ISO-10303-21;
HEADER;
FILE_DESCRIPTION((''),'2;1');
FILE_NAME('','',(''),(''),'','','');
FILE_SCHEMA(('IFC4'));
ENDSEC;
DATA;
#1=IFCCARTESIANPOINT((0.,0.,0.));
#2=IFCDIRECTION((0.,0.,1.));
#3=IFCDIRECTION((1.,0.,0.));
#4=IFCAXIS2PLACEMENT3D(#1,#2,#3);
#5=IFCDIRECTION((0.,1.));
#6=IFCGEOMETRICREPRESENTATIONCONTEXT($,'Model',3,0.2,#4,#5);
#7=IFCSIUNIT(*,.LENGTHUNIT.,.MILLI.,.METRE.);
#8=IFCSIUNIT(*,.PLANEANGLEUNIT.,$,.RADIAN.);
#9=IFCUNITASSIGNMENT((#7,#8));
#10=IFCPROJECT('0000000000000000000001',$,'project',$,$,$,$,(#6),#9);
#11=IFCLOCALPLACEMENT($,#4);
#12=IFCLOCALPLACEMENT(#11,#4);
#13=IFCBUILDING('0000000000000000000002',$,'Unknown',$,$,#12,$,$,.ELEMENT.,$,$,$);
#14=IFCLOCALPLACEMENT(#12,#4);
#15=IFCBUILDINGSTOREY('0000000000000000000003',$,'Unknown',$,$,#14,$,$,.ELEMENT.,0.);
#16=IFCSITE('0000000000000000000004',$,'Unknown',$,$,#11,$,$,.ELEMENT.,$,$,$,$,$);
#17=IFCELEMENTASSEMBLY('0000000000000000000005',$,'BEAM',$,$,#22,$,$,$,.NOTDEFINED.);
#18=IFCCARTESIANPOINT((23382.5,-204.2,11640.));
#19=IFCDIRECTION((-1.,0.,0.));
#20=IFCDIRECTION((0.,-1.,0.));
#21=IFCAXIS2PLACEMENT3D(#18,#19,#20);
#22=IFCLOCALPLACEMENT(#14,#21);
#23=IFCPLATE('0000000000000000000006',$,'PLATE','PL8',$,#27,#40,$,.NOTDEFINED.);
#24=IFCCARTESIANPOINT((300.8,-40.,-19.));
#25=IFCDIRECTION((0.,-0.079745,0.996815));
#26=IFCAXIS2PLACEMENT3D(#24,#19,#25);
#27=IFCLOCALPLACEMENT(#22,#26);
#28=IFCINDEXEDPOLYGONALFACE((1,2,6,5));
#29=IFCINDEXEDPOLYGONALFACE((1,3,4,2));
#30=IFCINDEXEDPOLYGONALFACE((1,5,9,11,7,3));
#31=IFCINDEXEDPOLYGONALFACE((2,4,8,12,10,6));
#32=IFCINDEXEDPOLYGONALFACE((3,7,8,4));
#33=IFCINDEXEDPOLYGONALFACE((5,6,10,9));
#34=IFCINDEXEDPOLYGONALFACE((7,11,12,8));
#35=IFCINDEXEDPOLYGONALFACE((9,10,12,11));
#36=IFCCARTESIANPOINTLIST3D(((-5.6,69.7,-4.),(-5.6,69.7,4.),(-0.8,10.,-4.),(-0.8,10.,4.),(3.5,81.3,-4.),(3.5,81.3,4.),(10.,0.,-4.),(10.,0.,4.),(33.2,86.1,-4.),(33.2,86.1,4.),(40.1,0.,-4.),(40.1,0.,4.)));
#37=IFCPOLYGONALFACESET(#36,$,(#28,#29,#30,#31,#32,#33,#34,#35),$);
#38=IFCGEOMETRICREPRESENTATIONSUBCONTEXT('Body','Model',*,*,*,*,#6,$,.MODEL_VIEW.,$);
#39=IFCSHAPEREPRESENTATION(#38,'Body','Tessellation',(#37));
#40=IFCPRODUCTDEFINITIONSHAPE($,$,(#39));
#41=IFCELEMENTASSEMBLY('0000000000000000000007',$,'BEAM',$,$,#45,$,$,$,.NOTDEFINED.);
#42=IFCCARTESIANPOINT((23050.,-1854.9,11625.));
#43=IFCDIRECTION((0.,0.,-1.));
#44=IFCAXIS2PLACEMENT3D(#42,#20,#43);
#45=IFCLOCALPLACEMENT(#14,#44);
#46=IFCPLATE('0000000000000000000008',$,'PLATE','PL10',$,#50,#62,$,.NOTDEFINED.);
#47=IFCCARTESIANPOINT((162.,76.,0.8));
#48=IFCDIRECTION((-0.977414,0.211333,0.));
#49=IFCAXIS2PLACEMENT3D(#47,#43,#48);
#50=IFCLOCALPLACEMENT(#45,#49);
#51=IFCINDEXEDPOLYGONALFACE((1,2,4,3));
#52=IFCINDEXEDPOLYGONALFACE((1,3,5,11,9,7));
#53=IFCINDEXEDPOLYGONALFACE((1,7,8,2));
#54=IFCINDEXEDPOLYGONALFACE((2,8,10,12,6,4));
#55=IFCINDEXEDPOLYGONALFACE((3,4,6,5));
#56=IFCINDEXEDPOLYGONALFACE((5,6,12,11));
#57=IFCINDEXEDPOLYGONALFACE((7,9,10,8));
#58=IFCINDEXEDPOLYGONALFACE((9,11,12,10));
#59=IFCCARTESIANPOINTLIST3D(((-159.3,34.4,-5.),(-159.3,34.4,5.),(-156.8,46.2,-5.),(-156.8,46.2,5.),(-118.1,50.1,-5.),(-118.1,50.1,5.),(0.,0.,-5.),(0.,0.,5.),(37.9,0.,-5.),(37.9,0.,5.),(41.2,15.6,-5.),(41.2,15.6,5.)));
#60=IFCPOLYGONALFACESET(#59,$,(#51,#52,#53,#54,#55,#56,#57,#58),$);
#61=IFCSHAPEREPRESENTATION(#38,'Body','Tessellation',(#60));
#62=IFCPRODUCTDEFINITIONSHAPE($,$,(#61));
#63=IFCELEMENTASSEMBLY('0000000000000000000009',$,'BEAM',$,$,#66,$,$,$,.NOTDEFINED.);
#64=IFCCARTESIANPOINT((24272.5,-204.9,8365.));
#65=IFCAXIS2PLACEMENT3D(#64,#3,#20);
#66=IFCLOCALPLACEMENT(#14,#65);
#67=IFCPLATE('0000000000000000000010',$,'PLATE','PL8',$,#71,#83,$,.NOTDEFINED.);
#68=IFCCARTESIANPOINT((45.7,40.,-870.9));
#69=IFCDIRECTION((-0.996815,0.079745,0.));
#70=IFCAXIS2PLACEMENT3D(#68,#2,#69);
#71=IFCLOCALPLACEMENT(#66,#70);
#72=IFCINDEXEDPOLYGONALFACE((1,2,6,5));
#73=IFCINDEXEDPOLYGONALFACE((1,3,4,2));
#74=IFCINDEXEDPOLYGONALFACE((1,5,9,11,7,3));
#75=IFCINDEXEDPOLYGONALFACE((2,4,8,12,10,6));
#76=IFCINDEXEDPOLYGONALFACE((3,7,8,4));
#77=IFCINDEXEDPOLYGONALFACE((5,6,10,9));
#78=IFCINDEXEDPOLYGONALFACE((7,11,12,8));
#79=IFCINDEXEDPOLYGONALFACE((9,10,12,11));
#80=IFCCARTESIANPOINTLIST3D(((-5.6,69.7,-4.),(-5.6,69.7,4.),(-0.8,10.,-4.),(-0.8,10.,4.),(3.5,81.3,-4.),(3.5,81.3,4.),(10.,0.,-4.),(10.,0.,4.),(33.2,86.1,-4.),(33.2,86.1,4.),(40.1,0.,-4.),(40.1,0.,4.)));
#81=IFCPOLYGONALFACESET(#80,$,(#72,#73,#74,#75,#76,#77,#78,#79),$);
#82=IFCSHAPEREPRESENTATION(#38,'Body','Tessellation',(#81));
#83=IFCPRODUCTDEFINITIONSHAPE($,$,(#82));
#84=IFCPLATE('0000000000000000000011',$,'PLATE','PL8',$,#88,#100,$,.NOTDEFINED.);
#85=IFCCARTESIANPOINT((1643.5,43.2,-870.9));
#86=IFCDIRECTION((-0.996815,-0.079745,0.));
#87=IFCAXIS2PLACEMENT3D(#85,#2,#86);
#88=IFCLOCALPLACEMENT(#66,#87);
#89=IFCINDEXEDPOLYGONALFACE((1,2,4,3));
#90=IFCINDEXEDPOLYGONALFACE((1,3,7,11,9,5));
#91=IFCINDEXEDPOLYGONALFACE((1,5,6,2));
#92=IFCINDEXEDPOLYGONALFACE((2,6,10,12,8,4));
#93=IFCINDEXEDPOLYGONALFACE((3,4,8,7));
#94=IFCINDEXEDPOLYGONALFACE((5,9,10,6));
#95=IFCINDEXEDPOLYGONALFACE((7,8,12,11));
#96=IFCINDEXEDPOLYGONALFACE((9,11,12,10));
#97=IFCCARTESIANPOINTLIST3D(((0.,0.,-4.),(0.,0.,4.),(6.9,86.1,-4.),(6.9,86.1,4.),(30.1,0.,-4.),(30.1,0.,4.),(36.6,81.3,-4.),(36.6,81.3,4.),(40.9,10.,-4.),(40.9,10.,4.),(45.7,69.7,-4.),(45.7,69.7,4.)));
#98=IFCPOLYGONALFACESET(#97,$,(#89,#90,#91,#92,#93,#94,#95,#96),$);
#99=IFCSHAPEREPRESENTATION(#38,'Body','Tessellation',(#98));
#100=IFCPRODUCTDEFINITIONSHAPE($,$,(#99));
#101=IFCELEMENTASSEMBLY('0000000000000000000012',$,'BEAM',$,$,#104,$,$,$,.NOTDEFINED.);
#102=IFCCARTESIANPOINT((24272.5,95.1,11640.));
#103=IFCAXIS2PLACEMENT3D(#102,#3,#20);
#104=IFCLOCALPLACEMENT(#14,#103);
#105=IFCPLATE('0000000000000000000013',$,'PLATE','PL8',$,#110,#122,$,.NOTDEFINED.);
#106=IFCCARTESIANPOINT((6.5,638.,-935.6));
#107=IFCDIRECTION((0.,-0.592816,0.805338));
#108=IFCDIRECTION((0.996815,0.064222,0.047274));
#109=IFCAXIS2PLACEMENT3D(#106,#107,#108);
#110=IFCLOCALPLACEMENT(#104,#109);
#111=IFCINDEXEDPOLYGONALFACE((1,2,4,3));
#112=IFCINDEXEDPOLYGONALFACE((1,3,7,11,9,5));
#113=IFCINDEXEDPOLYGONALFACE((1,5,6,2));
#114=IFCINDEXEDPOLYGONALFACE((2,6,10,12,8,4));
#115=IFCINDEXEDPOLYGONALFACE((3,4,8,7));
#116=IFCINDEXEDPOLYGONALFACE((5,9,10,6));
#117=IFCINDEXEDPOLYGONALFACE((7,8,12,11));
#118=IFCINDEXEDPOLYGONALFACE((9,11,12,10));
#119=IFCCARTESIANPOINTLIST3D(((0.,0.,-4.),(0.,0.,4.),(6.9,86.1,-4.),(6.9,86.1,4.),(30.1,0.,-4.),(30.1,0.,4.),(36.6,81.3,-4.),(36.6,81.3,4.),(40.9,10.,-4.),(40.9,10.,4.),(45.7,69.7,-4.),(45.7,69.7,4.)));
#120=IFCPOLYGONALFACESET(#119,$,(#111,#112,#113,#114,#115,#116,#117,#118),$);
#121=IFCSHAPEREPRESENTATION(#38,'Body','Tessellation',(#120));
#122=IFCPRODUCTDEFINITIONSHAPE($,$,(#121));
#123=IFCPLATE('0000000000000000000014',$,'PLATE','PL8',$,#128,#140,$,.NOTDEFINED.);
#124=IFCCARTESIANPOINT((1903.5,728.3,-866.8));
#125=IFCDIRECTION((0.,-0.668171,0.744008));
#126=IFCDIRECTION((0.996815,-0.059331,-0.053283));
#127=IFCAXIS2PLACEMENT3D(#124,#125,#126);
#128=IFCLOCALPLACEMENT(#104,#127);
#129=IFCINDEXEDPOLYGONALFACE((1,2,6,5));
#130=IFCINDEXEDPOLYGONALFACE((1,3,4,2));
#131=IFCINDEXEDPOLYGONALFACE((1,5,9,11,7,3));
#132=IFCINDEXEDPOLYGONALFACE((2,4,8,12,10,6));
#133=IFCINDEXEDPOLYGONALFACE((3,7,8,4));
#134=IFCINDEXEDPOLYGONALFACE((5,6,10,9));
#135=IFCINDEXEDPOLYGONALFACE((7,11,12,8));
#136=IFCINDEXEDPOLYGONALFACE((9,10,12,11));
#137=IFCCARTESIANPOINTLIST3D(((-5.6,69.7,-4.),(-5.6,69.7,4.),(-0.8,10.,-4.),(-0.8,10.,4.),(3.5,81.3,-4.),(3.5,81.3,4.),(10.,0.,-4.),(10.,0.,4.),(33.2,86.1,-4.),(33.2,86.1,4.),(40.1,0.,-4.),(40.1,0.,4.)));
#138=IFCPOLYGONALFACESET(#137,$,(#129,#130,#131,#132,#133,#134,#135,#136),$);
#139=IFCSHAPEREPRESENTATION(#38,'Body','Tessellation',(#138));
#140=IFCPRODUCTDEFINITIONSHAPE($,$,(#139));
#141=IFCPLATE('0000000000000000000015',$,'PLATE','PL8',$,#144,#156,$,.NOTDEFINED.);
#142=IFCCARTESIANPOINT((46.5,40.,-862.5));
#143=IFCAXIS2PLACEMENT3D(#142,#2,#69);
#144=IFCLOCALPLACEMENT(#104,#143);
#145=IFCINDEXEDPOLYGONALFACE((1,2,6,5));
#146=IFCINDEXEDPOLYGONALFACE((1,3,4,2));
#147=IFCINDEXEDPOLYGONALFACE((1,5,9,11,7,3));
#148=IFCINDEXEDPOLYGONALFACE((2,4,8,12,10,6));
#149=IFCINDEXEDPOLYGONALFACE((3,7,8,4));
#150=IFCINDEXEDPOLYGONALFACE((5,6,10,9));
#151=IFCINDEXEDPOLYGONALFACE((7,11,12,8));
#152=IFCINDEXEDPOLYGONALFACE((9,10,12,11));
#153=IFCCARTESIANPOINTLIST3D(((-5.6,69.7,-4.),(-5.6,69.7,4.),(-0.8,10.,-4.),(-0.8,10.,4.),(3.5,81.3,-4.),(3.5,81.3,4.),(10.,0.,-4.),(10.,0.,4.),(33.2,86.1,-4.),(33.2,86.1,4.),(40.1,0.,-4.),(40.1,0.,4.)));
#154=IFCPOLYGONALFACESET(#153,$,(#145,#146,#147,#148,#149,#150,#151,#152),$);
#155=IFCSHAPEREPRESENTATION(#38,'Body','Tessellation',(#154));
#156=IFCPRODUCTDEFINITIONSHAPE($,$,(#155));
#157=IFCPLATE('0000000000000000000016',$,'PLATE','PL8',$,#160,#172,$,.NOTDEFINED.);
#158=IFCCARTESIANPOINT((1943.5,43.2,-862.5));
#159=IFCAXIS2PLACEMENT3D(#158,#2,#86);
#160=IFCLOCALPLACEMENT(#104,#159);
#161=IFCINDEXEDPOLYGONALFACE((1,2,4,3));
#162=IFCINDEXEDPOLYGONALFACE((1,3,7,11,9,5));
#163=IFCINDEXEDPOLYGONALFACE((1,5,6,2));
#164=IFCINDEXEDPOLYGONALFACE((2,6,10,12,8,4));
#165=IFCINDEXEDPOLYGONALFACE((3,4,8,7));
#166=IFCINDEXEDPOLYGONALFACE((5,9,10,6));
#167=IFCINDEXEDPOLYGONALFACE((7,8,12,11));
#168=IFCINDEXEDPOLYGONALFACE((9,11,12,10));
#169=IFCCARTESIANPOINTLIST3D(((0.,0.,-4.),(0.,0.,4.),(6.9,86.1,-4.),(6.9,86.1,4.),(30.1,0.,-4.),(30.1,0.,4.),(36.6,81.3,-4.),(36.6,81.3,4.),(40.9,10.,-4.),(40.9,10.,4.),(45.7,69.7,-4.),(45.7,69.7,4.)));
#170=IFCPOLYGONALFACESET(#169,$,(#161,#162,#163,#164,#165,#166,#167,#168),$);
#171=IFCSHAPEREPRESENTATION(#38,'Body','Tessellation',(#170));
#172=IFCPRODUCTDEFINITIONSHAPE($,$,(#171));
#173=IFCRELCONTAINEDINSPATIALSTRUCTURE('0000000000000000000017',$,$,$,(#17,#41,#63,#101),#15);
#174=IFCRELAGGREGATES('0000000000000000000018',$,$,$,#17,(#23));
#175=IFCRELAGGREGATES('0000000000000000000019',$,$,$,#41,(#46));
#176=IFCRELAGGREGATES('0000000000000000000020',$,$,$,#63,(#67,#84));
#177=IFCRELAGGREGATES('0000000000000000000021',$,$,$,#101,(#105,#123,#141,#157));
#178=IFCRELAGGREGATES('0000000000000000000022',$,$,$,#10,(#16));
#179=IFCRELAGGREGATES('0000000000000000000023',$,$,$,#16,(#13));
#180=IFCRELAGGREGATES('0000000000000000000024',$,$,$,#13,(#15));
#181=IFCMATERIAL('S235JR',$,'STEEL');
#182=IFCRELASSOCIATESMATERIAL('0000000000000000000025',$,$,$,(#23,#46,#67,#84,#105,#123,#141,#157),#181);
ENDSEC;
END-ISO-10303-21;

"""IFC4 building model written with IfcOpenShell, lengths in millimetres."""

from ifc_helpers import new_model, si_unit, direction, frame, origin_with_axes, place, context, subcontext, project, spatial, line, indexed_curve, outline, extrude, material, element, aggregate, save


model = new_model("IFC4")

# Units and contexts
model_context = context("Model", 3, precision=0.2, world=origin_with_axes(), true_north=direction((0.0, 1.0)))
body_context = subcontext(model_context, "Body", "Model", "MODEL_VIEW")
ifc_project = project(units=[si_unit("LENGTHUNIT", "METRE", prefix="MILLI"), si_unit("PLANEANGLEUNIT", "RADIAN")], contexts=[model_context])

# Site, building, storey
site_placement = place(None, origin_with_axes())
site = spatial("IfcSite", under=ifc_project, at=site_placement, Name="Unknown", CompositionType="ELEMENT")
building_placement = place(site_placement, origin_with_axes())
building = spatial("IfcBuilding", under=site, at=building_placement, Name="Unknown", CompositionType="ELEMENT")
storey_placement = place(building_placement, origin_with_axes())
storey = spatial("IfcBuildingStorey", under=building, at=storey_placement, Name="Unknown", CompositionType="ELEMENT", Elevation=0.0)

# Shared definitions
ifc_material = material(Name="S235JR", Category="STEEL")

# Element assembly, plate
assembly_1_placement = place(storey_placement, frame((23382.5, -204.2, 11640.0), z_axis=(-1.0, 0.0, 0.0), x_axis=(0.0, -1.0, 0.0)))
assembly_1 = element("IfcElementAssembly", 1, at=assembly_1_placement, inside=storey, Name="BEAM", PredefinedType="NOTDEFINED")
plate_1_placement = place(assembly_1_placement, frame((300.8, -40.0, -19.0), z_axis=(-1.0, 0.0, 0.0), x_axis=(0.0, -0.079745, 0.996815)))
plate_1 = element("IfcPlate", 2, at=plate_1_placement, material=ifc_material, Name="PLATE", Description="PL8", PredefinedType="NOTDEFINED", context=body_context, shape_type="SolidModel", body=[
    extrude(outline(indexed_curve([(-0.8, 10.0), (10.0, 0.0), (40.1, 0.0), (33.2, 86.1), (3.5, 81.3), (-5.6, 69.7)], segments=[line(1, 2, 3, 4, 5, 6, 1)])), frame((0.0, 0.0, 4.0), z_axis=(0.0, 0.0, 1.0), x_axis=(1.0, 0.0, 0.0)), (0.0, 0.0, -1.0), 8.0),
])
aggregate(assembly_1, [plate_1])

# Element assemblies, plates
assembly_2_placement = place(storey_placement, frame((23050.0, -1854.9, 11625.0), z_axis=(0.0, -1.0, 0.0), x_axis=(0.0, 0.0, -1.0)))
assembly_2 = element("IfcElementAssembly", 3, at=assembly_2_placement, inside=storey, Name="BEAM", PredefinedType="NOTDEFINED")
plate_2_placement = place(assembly_2_placement, frame((162.0, 76.0, 0.8), z_axis=(0.0, 0.0, -1.0), x_axis=(-0.977414, 0.211333, 0.0)))
plate_2 = element("IfcPlate", 4, at=plate_2_placement, material=ifc_material, Name="PLATE", Description="PL10", PredefinedType="NOTDEFINED", context=body_context, shape_type="SolidModel", body=[
    extrude(outline(indexed_curve([(0.0, 0.0), (37.9, 0.0), (41.2, 15.6), (-118.1, 50.1), (-156.8, 46.2), (-159.3, 34.4)], segments=[line(1, 2, 3, 4, 5, 6, 1)])), frame((0.0, 0.0, 5.0), z_axis=(0.0, 0.0, 1.0), x_axis=(1.0, 0.0, 0.0)), (0.0, 0.0, -1.0), 10.0),
])
aggregate(assembly_2, [plate_2])
assembly_3_placement = place(storey_placement, frame((24272.5, -204.9, 8365.0), z_axis=(1.0, 0.0, 0.0), x_axis=(0.0, -1.0, 0.0)))
assembly_3 = element("IfcElementAssembly", 5, at=assembly_3_placement, inside=storey, Name="BEAM", PredefinedType="NOTDEFINED")
plate_3_placement = place(assembly_3_placement, frame((45.7, 40.0, -870.9), z_axis=(0.0, 0.0, 1.0), x_axis=(-0.996815, 0.079745, 0.0)))
plate_3 = element("IfcPlate", 6, at=plate_3_placement, material=ifc_material, Name="PLATE", Description="PL8", PredefinedType="NOTDEFINED", context=body_context, shape_type="SolidModel", body=[
    extrude(outline(indexed_curve([(-0.8, 10.0), (10.0, 0.0), (40.1, 0.0), (33.2, 86.1), (3.5, 81.3), (-5.6, 69.7)], segments=[line(1, 2, 3, 4, 5, 6, 1)])), frame((0.0, 0.0, 4.0), z_axis=(0.0, 0.0, 1.0), x_axis=(1.0, 0.0, 0.0)), (0.0, 0.0, -1.0), 8.0),
])
plate_4_placement = place(assembly_3_placement, frame((1643.5, 43.2, -870.9), z_axis=(0.0, 0.0, 1.0), x_axis=(-0.996815, -0.079745, 0.0)))
plate_4 = element("IfcPlate", 7, at=plate_4_placement, material=ifc_material, Name="PLATE", Description="PL8", PredefinedType="NOTDEFINED", context=body_context, shape_type="SolidModel", body=[
    extrude(outline(indexed_curve([(0.0, 0.0), (30.1, 0.0), (40.9, 10.0), (45.7, 69.7), (36.6, 81.3), (6.9, 86.1)], segments=[line(1, 2, 3, 4, 5, 6, 1)])), frame((0.0, 0.0, 4.0), z_axis=(0.0, 0.0, 1.0), x_axis=(1.0, 0.0, 0.0)), (0.0, 0.0, -1.0), 8.0),
])
aggregate(assembly_3, [plate_3, plate_4])
assembly_4_placement = place(storey_placement, frame((24272.5, 95.1, 11640.0), z_axis=(1.0, 0.0, 0.0), x_axis=(0.0, -1.0, 0.0)))
assembly_4 = element("IfcElementAssembly", 8, at=assembly_4_placement, inside=storey, Name="BEAM", PredefinedType="NOTDEFINED")
plate_5_placement = place(assembly_4_placement, frame((6.5, 638.0, -935.6), z_axis=(0.0, -0.592816, 0.805338), x_axis=(0.996815, 0.064222, 0.047274)))
plate_5 = element("IfcPlate", 9, at=plate_5_placement, material=ifc_material, Name="PLATE", Description="PL8", PredefinedType="NOTDEFINED", context=body_context, shape_type="SolidModel", body=[
    extrude(outline(indexed_curve([(0.0, 0.0), (30.1, 0.0), (40.9, 10.0), (45.7, 69.7), (36.6, 81.3), (6.9, 86.1)], segments=[line(1, 2, 3, 4, 5, 6, 1)])), frame((0.0, 0.0, 4.0), z_axis=(0.0, 0.0, 1.0), x_axis=(1.0, 0.0, 0.0)), (0.0, 0.0, -1.0), 8.0),
])
plate_6_placement = place(assembly_4_placement, frame((1903.5, 728.3, -866.8), z_axis=(0.0, -0.668171, 0.744008), x_axis=(0.996815, -0.059331, -0.053283)))
plate_6 = element("IfcPlate", 10, at=plate_6_placement, material=ifc_material, Name="PLATE", Description="PL8", PredefinedType="NOTDEFINED", context=body_context, shape_type="SolidModel", body=[
    extrude(outline(indexed_curve([(-0.8, 10.0), (10.0, 0.0), (40.1, 0.0), (33.2, 86.1), (3.5, 81.3), (-5.6, 69.7)], segments=[line(1, 2, 3, 4, 5, 6, 1)])), frame((0.0, 0.0, 4.0), z_axis=(0.0, 0.0, 1.0), x_axis=(1.0, 0.0, 0.0)), (0.0, 0.0, -1.0), 8.0),
])
plate_7_placement = place(assembly_4_placement, frame((46.5, 40.0, -862.5), z_axis=(0.0, 0.0, 1.0), x_axis=(-0.996815, 0.079745, 0.0)))
plate_7 = element("IfcPlate", 11, at=plate_7_placement, material=ifc_material, Name="PLATE", Description="PL8", PredefinedType="NOTDEFINED", context=body_context, shape_type="SolidModel", body=[
    extrude(outline(indexed_curve([(-0.8, 10.0), (10.0, 0.0), (40.1, 0.0), (33.2, 86.1), (3.5, 81.3), (-5.6, 69.7)], segments=[line(1, 2, 3, 4, 5, 6, 1)])), frame((0.0, 0.0, 4.0), z_axis=(0.0, 0.0, 1.0), x_axis=(1.0, 0.0, 0.0)), (0.0, 0.0, -1.0), 8.0),
])
plate_8_placement = place(assembly_4_placement, frame((1943.5, 43.2, -862.5), z_axis=(0.0, 0.0, 1.0), x_axis=(-0.996815, -0.079745, 0.0)))
plate_8 = element("IfcPlate", 12, at=plate_8_placement, material=ifc_material, Name="PLATE", Description="PL8", PredefinedType="NOTDEFINED", context=body_context, shape_type="SolidModel", body=[
    extrude(outline(indexed_curve([(0.0, 0.0), (30.1, 0.0), (40.9, 10.0), (45.7, 69.7), (36.6, 81.3), (6.9, 86.1)], segments=[line(1, 2, 3, 4, 5, 6, 1)])), frame((0.0, 0.0, 4.0), z_axis=(0.0, 0.0, 1.0), x_axis=(1.0, 0.0, 0.0)), (0.0, 0.0, -1.0), 8.0),
])
aggregate(assembly_4, [plate_5, plate_6, plate_7, plate_8])

save(model, "model.ifc")
